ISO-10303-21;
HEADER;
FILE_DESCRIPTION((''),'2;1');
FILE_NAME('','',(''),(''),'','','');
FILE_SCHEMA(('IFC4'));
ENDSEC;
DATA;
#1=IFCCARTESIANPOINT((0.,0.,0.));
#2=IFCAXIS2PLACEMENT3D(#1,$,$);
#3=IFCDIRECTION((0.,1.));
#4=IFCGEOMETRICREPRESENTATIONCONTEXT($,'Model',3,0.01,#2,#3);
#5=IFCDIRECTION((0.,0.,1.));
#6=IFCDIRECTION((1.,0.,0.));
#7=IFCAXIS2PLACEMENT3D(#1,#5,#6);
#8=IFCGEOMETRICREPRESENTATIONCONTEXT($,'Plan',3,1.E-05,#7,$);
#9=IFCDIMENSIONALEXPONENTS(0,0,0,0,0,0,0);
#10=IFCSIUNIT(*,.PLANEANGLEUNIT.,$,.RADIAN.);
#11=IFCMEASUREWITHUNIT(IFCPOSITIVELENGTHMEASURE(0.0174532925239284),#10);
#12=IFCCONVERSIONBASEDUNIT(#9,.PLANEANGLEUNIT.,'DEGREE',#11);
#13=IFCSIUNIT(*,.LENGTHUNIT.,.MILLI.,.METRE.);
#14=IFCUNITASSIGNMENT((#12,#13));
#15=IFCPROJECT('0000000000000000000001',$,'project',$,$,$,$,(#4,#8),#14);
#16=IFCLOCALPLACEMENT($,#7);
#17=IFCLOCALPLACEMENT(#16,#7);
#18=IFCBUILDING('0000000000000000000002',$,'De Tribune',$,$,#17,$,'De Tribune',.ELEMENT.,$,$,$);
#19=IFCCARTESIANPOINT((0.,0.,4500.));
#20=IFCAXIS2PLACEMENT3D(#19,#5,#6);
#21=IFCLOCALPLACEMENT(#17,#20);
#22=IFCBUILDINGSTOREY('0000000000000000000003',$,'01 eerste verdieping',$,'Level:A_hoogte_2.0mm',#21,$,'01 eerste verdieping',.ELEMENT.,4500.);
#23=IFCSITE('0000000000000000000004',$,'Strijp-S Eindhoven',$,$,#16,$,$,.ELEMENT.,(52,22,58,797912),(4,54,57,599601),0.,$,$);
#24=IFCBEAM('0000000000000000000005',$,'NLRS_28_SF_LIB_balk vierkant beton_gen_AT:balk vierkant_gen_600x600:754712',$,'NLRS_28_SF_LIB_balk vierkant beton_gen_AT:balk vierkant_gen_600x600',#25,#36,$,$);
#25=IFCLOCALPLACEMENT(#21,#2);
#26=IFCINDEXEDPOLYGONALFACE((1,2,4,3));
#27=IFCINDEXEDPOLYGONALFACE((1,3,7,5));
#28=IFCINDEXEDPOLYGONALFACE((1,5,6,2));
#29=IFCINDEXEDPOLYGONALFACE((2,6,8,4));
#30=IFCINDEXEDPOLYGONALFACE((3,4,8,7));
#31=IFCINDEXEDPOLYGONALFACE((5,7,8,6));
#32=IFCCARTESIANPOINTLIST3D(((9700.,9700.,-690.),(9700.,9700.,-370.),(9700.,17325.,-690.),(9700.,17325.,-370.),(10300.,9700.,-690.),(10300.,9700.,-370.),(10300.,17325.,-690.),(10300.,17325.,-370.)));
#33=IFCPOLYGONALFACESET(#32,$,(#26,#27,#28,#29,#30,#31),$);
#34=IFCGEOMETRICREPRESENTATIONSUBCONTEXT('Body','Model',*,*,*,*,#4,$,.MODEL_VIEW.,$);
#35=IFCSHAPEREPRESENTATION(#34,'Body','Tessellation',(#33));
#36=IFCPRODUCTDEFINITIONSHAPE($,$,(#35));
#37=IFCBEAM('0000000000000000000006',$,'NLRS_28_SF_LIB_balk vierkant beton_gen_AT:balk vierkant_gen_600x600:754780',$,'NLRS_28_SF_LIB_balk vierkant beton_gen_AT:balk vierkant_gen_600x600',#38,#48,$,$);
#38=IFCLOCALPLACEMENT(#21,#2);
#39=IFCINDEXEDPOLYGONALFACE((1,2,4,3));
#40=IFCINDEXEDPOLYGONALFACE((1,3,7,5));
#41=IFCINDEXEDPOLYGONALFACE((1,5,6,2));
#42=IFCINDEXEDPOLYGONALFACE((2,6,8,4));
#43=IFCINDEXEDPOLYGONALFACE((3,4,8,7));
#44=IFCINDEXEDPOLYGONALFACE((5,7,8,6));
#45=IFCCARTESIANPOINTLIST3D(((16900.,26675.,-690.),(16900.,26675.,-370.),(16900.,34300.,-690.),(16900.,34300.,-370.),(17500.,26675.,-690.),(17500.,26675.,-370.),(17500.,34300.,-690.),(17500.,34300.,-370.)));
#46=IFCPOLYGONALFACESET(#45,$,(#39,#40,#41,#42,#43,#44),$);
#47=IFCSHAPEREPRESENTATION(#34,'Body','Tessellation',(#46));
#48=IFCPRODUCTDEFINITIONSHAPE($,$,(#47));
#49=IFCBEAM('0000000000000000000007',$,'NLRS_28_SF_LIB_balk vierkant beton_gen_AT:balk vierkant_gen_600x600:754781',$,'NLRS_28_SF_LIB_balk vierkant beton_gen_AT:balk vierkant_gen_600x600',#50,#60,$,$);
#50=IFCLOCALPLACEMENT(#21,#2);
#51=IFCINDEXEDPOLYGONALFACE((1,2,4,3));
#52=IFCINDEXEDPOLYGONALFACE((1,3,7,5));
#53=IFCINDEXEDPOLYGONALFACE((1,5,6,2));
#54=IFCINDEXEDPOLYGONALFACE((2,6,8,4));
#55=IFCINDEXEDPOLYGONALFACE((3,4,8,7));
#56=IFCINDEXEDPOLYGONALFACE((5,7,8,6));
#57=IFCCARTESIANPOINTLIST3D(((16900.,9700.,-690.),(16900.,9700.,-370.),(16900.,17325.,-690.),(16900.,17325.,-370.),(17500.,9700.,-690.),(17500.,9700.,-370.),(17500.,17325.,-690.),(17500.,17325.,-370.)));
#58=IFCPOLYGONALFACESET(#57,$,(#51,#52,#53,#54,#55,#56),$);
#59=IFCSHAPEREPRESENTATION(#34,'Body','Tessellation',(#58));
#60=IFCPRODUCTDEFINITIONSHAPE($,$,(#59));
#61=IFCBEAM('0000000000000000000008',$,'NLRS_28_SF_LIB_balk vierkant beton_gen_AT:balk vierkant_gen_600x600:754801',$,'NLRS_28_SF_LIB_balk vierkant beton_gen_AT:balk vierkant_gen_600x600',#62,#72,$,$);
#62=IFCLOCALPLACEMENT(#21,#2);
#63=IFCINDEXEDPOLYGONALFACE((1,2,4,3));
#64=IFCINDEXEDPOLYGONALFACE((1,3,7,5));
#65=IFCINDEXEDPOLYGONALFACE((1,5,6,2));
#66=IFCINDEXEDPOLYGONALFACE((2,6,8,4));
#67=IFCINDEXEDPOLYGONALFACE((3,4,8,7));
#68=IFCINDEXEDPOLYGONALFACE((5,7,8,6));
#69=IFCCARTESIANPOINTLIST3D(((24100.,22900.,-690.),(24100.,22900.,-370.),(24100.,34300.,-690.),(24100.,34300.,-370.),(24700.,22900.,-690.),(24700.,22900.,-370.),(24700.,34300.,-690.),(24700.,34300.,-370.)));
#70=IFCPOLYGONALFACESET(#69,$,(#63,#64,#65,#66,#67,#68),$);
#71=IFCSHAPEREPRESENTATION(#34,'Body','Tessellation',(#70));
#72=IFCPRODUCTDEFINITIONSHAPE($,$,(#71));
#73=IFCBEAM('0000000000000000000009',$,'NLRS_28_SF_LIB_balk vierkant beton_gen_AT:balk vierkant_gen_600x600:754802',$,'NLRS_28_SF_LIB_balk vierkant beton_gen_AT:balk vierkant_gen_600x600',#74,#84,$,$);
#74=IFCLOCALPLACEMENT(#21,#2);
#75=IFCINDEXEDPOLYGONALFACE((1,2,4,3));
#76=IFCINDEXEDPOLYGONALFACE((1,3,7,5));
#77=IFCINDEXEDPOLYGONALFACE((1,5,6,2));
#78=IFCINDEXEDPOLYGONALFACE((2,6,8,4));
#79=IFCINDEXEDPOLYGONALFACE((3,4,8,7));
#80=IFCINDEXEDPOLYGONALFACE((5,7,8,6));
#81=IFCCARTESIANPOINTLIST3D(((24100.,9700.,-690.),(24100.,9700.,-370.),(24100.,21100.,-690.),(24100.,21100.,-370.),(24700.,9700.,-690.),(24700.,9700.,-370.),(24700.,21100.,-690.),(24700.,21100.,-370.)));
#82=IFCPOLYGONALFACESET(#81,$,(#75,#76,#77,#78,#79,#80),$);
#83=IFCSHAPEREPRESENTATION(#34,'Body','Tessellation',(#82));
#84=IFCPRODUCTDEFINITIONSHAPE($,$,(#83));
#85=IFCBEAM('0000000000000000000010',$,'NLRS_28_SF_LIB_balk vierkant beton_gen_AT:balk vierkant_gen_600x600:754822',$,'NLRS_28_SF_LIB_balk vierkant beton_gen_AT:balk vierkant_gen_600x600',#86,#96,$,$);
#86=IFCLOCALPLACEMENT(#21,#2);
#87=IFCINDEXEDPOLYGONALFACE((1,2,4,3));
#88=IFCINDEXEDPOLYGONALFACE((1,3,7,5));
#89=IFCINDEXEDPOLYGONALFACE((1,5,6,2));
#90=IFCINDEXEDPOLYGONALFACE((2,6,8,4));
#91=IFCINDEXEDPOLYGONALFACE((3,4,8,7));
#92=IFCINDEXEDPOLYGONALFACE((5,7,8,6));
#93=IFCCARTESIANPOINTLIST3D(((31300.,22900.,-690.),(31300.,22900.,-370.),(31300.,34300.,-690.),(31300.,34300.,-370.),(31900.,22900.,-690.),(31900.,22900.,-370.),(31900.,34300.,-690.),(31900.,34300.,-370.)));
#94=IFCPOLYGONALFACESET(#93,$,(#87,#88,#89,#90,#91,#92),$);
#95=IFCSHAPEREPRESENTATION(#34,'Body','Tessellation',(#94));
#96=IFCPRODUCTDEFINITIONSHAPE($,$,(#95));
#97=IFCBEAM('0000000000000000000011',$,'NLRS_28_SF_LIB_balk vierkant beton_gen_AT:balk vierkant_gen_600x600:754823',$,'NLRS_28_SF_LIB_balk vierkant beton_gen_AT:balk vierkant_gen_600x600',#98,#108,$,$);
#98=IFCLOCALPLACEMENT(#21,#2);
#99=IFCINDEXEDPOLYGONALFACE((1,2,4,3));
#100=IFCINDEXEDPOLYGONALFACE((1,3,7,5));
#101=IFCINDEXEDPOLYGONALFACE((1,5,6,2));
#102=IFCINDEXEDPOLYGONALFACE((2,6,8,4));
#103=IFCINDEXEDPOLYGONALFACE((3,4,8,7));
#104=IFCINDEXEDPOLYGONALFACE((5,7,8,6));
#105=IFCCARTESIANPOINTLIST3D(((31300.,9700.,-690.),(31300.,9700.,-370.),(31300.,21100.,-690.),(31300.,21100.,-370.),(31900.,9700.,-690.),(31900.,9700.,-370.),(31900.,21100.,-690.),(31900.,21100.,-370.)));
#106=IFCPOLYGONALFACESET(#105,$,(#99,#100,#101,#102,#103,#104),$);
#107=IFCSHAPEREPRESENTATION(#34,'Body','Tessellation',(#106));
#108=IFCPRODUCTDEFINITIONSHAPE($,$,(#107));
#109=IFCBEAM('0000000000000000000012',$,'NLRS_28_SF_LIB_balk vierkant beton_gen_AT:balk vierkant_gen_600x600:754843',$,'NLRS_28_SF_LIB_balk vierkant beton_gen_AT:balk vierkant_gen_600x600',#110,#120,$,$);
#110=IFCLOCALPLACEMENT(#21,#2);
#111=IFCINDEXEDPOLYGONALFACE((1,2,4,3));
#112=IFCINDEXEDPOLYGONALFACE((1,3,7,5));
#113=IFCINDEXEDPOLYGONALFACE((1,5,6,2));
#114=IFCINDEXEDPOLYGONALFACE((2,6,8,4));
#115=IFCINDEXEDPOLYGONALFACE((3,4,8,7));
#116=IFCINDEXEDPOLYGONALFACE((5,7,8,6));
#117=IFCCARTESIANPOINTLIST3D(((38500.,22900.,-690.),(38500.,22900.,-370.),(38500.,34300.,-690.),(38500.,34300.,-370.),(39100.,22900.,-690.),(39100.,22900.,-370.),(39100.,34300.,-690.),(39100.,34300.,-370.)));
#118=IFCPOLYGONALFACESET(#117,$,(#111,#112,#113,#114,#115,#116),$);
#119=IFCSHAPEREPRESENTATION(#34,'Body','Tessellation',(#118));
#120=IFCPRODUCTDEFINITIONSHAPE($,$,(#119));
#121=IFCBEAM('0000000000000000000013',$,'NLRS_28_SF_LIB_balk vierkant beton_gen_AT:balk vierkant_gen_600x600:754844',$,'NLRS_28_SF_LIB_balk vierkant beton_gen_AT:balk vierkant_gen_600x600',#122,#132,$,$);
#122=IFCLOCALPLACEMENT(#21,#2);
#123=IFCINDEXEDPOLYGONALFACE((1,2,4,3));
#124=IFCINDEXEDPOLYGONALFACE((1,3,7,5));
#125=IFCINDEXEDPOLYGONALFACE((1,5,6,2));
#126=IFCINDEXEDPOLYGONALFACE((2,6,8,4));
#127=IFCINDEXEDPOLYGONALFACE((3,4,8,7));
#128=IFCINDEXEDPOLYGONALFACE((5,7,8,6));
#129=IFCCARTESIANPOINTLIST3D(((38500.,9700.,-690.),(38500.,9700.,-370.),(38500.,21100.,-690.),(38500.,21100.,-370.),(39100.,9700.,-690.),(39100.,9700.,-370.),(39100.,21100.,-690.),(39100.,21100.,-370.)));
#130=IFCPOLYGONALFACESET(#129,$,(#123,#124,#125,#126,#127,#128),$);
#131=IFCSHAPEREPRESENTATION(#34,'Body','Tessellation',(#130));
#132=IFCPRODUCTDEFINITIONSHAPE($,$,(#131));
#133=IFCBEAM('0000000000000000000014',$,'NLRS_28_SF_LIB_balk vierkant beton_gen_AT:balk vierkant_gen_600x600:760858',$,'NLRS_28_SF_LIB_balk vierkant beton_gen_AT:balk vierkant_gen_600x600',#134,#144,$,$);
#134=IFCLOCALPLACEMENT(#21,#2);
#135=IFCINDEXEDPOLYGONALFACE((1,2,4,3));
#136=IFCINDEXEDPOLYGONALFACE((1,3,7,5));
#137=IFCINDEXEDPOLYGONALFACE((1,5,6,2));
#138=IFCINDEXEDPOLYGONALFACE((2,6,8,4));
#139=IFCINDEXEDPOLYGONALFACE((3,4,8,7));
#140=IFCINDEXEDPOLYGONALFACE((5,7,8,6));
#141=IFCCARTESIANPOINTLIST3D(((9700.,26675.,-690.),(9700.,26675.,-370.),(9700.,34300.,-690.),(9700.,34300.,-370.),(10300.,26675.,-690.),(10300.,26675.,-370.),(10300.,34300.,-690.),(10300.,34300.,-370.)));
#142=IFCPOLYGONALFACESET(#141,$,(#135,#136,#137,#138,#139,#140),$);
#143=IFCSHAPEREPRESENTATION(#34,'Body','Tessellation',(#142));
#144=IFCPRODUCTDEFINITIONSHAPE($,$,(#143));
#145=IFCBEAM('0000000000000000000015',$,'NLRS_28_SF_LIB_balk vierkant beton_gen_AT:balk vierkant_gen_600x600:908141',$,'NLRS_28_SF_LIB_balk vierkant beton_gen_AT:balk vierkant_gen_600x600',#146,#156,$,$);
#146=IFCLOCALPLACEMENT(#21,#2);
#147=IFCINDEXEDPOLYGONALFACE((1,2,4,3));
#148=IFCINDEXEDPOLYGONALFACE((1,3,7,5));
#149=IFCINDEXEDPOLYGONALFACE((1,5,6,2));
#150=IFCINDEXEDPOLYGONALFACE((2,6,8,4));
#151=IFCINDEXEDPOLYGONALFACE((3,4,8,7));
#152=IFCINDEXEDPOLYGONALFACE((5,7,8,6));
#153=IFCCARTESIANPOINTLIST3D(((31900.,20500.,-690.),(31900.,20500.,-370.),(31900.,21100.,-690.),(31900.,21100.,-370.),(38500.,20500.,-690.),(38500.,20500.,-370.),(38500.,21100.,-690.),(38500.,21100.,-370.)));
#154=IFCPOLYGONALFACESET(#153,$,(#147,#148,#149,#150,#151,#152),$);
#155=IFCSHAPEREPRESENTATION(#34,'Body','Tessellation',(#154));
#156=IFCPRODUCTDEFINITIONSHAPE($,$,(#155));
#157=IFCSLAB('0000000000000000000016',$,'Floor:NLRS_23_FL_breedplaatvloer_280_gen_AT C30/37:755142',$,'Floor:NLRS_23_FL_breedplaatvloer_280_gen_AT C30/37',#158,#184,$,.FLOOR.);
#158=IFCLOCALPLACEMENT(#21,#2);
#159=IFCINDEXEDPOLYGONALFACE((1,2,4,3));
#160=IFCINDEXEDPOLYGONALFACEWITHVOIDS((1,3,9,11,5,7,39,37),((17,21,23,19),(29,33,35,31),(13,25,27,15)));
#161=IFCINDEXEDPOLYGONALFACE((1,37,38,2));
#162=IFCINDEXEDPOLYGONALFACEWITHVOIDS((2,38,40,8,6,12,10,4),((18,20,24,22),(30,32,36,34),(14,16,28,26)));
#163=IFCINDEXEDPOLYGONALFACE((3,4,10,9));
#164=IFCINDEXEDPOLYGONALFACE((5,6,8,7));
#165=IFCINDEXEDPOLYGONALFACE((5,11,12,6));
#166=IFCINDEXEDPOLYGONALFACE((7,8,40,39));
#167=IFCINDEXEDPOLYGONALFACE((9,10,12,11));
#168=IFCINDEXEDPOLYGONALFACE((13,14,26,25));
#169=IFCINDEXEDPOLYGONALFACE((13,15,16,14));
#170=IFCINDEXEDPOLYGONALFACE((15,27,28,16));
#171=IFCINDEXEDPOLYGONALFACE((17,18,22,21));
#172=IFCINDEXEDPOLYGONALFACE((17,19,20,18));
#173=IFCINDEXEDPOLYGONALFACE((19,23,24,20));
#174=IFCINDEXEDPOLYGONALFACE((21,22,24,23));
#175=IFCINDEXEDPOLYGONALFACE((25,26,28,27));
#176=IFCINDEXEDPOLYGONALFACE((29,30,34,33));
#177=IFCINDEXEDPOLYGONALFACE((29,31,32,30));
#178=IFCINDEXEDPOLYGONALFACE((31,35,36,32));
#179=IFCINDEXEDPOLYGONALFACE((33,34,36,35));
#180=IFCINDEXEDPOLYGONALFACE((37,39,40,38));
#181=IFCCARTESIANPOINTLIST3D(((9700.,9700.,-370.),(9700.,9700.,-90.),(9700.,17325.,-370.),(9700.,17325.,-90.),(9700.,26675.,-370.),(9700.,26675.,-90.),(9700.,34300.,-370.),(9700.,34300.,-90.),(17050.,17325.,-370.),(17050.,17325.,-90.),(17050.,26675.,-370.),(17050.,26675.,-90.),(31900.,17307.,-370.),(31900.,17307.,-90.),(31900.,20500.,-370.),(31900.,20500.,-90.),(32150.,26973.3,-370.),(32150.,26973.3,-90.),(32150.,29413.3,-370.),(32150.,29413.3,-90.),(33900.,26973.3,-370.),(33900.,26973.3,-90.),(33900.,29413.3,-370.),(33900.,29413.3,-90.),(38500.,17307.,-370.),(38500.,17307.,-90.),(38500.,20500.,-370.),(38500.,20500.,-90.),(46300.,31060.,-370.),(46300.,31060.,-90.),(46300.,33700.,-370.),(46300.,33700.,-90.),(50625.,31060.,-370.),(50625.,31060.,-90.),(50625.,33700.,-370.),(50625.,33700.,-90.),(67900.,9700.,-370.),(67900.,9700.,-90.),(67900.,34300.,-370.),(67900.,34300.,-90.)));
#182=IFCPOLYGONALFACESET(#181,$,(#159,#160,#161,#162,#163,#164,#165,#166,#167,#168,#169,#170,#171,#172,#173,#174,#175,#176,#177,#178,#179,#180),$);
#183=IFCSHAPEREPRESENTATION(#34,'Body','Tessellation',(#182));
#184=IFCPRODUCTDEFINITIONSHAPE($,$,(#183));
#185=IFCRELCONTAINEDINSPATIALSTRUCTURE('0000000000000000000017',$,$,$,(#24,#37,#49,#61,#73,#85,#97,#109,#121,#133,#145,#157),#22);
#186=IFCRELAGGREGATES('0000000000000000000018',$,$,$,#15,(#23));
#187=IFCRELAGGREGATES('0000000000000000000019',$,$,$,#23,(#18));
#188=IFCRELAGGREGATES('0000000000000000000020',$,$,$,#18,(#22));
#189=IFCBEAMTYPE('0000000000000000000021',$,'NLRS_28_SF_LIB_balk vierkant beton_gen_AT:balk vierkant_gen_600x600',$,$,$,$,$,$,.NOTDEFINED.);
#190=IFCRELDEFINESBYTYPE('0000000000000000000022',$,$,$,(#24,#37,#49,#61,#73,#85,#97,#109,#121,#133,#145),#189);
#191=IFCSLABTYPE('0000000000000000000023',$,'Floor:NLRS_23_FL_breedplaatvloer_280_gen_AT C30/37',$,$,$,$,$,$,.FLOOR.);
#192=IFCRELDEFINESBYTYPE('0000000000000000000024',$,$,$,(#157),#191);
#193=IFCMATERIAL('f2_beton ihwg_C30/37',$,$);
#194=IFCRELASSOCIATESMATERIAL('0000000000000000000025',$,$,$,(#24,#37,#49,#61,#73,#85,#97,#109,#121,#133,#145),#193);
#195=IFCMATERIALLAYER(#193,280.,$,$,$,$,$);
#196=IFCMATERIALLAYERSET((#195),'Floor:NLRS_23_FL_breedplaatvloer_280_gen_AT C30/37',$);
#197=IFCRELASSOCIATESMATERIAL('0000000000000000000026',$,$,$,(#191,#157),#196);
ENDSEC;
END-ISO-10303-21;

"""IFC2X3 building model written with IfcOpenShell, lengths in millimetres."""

from ifc_helpers import new_model, entity, si_unit, converted_unit, direction, frame, frame_2d, origin, origin_with_axes, place, context, subcontext, project, spatial, polyline, rectangle, outline, extrude, material, layer, layer_set, layer_usage, type_object, element, save


model = new_model("IFC2X3")

# Units and contexts
model_context = context("Model", 3, precision=0.01, world=origin(), true_north=direction((0.0, 1.0)))
plan_context = context("Plan", 3, precision=1e-05, world=origin_with_axes())
body_context = subcontext(model_context, "Body", "Model", "MODEL_VIEW")
ifc_project = project(units=[converted_unit("PLANEANGLEUNIT", "DEGREE", entity("IfcPositiveLengthMeasure", 0.0174532925239284), si_unit("PLANEANGLEUNIT", "RADIAN"), dimensions=[0, 0, 0, 0, 0, 0, 0]), si_unit("LENGTHUNIT", "METRE", prefix="MILLI")], contexts=[model_context, plan_context])

# Site, building, storey
site_placement = place(None, origin_with_axes())
site = spatial("IfcSite", under=ifc_project, at=site_placement, Name="Strijp-S Eindhoven", CompositionType="ELEMENT", RefLatitude=(52, 22, 58, 797912), RefLongitude=(4, 54, 57, 599601), RefElevation=0.0)
building_placement = place(site_placement, origin_with_axes())
building = spatial("IfcBuilding", under=site, at=building_placement, Name="De Tribune", LongName="De Tribune", CompositionType="ELEMENT")
storey_placement = place(building_placement, frame((0.0, 0.0, 4500.0), z_axis=(0.0, 0.0, 1.0), x_axis=(1.0, 0.0, 0.0)))
storey = spatial("IfcBuildingStorey", under=building, at=storey_placement, Name="01 eerste verdieping", ObjectType="Level:A_hoogte_2.0mm", LongName="01 eerste verdieping", CompositionType="ELEMENT", Elevation=4500.0)

# Shared definitions
ifc_material = material(Name="f2_beton ihwg_C30/37")

# Beams
beam_type = type_object("IfcBeamType", Name="NLRS_28_SF_LIB_balk vierkant beton_gen_AT:balk vierkant_gen_600x600", PredefinedType="NOTDEFINED")
for number, where, z_axis, x_axis, name in (
    (1, (10000.0, 17325.0, 0.0), (0.0, 0.0, 1.0), (0.0, -1.0, 0.0), "NLRS_28_SF_LIB_balk vierkant beton_gen_AT:balk vierkant_gen_600x600:754712"),
    (2, (17200.0, 34300.0, 0.0), (0.0, 0.0, 1.0), (0.0, -1.0, 0.0), "NLRS_28_SF_LIB_balk vierkant beton_gen_AT:balk vierkant_gen_600x600:754780"),
    (3, (17200.0, 17325.0, 0.0), (0.0, 0.0, 1.0), (0.0, -1.0, 0.0), "NLRS_28_SF_LIB_balk vierkant beton_gen_AT:balk vierkant_gen_600x600:754781"),
):
    element("IfcBeam", number, at=place(storey_placement, frame(where, z_axis=z_axis, x_axis=x_axis)), inside=storey, type_object=beam_type, material=ifc_material, Name=name, ObjectType="NLRS_28_SF_LIB_balk vierkant beton_gen_AT:balk vierkant_gen_600x600", context=body_context, shape_type="SweptSolid", body=[
        extrude(rectangle(XDim=320.0, YDim=600.0, at=frame_2d((0.0, 0.0), x_axis=(1.0, 0.0))), frame((0.0, 0.0, -530.0), z_axis=(1.0, 0.0, 0.0), x_axis=(0.0, 0.0, -1.0)), (0.0, 0.0, 1.0), 7625.0),
    ])
for number, where, z_axis, x_axis, name in (
    (4, (24400.0, 34300.0, 0.0), (0.0, 0.0, 1.0), (0.0, -1.0, 0.0), "NLRS_28_SF_LIB_balk vierkant beton_gen_AT:balk vierkant_gen_600x600:754801"),
    (5, (24400.0, 21100.0, 0.0), (0.0, 0.0, 1.0), (0.0, -1.0, 0.0), "NLRS_28_SF_LIB_balk vierkant beton_gen_AT:balk vierkant_gen_600x600:754802"),
    (6, (31600.0, 34300.0, 0.0), (0.0, 0.0, 1.0), (0.0, -1.0, 0.0), "NLRS_28_SF_LIB_balk vierkant beton_gen_AT:balk vierkant_gen_600x600:754822"),
    (7, (31600.0, 21100.0, 0.0), (0.0, 0.0, 1.0), (0.0, -1.0, 0.0), "NLRS_28_SF_LIB_balk vierkant beton_gen_AT:balk vierkant_gen_600x600:754823"),
    (8, (38800.0, 34300.0, 0.0), (0.0, 0.0, 1.0), (0.0, -1.0, 0.0), "NLRS_28_SF_LIB_balk vierkant beton_gen_AT:balk vierkant_gen_600x600:754843"),
    (9, (38800.0, 21100.0, 0.0), (0.0, 0.0, 1.0), (0.0, -1.0, 0.0), "NLRS_28_SF_LIB_balk vierkant beton_gen_AT:balk vierkant_gen_600x600:754844"),
):
    element("IfcBeam", number, at=place(storey_placement, frame(where, z_axis=z_axis, x_axis=x_axis)), inside=storey, type_object=beam_type, material=ifc_material, Name=name, ObjectType="NLRS_28_SF_LIB_balk vierkant beton_gen_AT:balk vierkant_gen_600x600", context=body_context, shape_type="SweptSolid", body=[
        extrude(rectangle(XDim=320.0, YDim=600.0, at=frame_2d((0.0, 0.0), x_axis=(1.0, 0.0))), frame((0.0, 0.0, -530.0), z_axis=(1.0, 0.0, 0.0), x_axis=(0.0, 0.0, -1.0)), (0.0, 0.0, 1.0), 11400.0),
    ])
beam_1_placement = place(storey_placement, frame((10000.0, 34300.0, 0.0), z_axis=(0.0, 0.0, 1.0), x_axis=(0.0, -1.0, 0.0)))
element("IfcBeam", 10, at=beam_1_placement, inside=storey, type_object=beam_type, material=ifc_material, Name="NLRS_28_SF_LIB_balk vierkant beton_gen_AT:balk vierkant_gen_600x600:760858", ObjectType="NLRS_28_SF_LIB_balk vierkant beton_gen_AT:balk vierkant_gen_600x600", context=body_context, shape_type="SweptSolid", body=[
    extrude(rectangle(XDim=320.0, YDim=600.0, at=frame_2d((0.0, 0.0), x_axis=(1.0, 0.0))), frame((0.0, 0.0, -530.0), z_axis=(1.0, 0.0, 0.0), x_axis=(0.0, 0.0, -1.0)), (0.0, 0.0, 1.0), 7625.0),
])
beam_2_placement = place(storey_placement, frame((31300.0, 20800.0, 0.0), z_axis=(0.0, 0.0, 1.0), x_axis=(1.0, 0.0, 0.0)))
element("IfcBeam", 11, at=beam_2_placement, inside=storey, type_object=beam_type, material=ifc_material, Name="NLRS_28_SF_LIB_balk vierkant beton_gen_AT:balk vierkant_gen_600x600:908141", ObjectType="NLRS_28_SF_LIB_balk vierkant beton_gen_AT:balk vierkant_gen_600x600", context=body_context, shape_type="SweptSolid", body=[
    extrude(rectangle(XDim=320.0, YDim=600.0, at=frame_2d((0.0, 0.0), x_axis=(1.0, 0.0))), frame((600.0, 0.0, -530.0), z_axis=(1.0, 0.0, 0.0), x_axis=(0.0, 0.0, -1.0)), (0.0, 0.0, 1.0), 6600.0),
])

# Slab, openings
ifc_layer_1 = layer(ifc_material, 280.0)
ifc_layer_set_1 = layer_set([ifc_layer_1], Name="Floor:NLRS_23_FL_breedplaatvloer_280_gen_AT C30/37")
ifc_layer_usage_1 = layer_usage(ifc_layer_set_1, "AXIS3", "POSITIVE", 0.0)
slab_type = type_object("IfcSlabType", Name="Floor:NLRS_23_FL_breedplaatvloer_280_gen_AT C30/37", PredefinedType="FLOOR", material=ifc_layer_set_1)
slab_placement = place(storey_placement, frame((9700.0, 9700.0, -370.0), z_axis=(0.0, 0.0, 1.0), x_axis=(1.0, 0.0, 0.0)))
slab = element("IfcSlab", 12, at=slab_placement, inside=storey, type_object=slab_type, material=ifc_layer_usage_1, Name="Floor:NLRS_23_FL_breedplaatvloer_280_gen_AT C30/37:755142", ObjectType="Floor:NLRS_23_FL_breedplaatvloer_280_gen_AT C30/37", PredefinedType="FLOOR", context=body_context, shape_type="SweptSolid", body=[
    extrude(outline(polyline([(-29100.0, 12300.0), (-29100.0, -12300.0), (29100.0, -12300.0), (29100.0, -4675.0), (21750.0, -4675.0), (21750.0, 4675.0), (25150.4, 4675.0), (29100.0, 4675.0), (29100.0, 12300.0), (-29100.0, 12300.0)])), frame((29100.0, 12300.0, 280.0), z_axis=(0.0, 0.0, -1.0), x_axis=(-1.0, 0.0, 0.0)), (0.0, 0.0, 1.0), 280.0),
])
opening_1_placement = place(slab_placement, origin_with_axes())
element("IfcOpeningElement", 13, at=opening_1_placement, cuts=slab, ObjectType="Opening", context=body_context, shape_type="SweptSolid", body=[
    extrude(rectangle(XDim=2640.0, YDim=4325.0, at=frame_2d((0.0, 0.0), x_axis=(1.0, 0.0))), frame((38762.5, 22680.0, 280.0), z_axis=(0.0, 0.0, -1.0), x_axis=(0.0, 1.0, 0.0)), (0.0, 0.0, 1.0), 280.0),
])
opening_2_placement = place(slab_placement, origin_with_axes())
element("IfcOpeningElement", 14, at=opening_2_placement, cuts=slab, ObjectType="Opening", context=body_context, shape_type="SweptSolid", body=[
    extrude(rectangle(XDim=3193.0, YDim=6600.0, at=frame_2d((0.0, 0.0), x_axis=(1.0, 0.0))), frame((25500.0, 9203.5, 280.0), z_axis=(0.0, 0.0, -1.0), x_axis=(0.0, 1.0, 0.0)), (0.0, 0.0, 1.0), 280.0),
])
opening_3_placement = place(slab_placement, origin_with_axes())
element("IfcOpeningElement", 15, at=opening_3_placement, cuts=slab, ObjectType="Opening", context=body_context, shape_type="SweptSolid", body=[
    extrude(rectangle(XDim=1750.0, YDim=2440.0, at=frame_2d((0.0, 0.0), x_axis=(1.0, 0.0))), frame((23325.0, 18493.3, 280.0), z_axis=(0.0, 0.0, -1.0), x_axis=(1.0, 0.0, 0.0)), (0.0, 0.0, 1.0), 280.0),
])

save(model, "model.ifc")
